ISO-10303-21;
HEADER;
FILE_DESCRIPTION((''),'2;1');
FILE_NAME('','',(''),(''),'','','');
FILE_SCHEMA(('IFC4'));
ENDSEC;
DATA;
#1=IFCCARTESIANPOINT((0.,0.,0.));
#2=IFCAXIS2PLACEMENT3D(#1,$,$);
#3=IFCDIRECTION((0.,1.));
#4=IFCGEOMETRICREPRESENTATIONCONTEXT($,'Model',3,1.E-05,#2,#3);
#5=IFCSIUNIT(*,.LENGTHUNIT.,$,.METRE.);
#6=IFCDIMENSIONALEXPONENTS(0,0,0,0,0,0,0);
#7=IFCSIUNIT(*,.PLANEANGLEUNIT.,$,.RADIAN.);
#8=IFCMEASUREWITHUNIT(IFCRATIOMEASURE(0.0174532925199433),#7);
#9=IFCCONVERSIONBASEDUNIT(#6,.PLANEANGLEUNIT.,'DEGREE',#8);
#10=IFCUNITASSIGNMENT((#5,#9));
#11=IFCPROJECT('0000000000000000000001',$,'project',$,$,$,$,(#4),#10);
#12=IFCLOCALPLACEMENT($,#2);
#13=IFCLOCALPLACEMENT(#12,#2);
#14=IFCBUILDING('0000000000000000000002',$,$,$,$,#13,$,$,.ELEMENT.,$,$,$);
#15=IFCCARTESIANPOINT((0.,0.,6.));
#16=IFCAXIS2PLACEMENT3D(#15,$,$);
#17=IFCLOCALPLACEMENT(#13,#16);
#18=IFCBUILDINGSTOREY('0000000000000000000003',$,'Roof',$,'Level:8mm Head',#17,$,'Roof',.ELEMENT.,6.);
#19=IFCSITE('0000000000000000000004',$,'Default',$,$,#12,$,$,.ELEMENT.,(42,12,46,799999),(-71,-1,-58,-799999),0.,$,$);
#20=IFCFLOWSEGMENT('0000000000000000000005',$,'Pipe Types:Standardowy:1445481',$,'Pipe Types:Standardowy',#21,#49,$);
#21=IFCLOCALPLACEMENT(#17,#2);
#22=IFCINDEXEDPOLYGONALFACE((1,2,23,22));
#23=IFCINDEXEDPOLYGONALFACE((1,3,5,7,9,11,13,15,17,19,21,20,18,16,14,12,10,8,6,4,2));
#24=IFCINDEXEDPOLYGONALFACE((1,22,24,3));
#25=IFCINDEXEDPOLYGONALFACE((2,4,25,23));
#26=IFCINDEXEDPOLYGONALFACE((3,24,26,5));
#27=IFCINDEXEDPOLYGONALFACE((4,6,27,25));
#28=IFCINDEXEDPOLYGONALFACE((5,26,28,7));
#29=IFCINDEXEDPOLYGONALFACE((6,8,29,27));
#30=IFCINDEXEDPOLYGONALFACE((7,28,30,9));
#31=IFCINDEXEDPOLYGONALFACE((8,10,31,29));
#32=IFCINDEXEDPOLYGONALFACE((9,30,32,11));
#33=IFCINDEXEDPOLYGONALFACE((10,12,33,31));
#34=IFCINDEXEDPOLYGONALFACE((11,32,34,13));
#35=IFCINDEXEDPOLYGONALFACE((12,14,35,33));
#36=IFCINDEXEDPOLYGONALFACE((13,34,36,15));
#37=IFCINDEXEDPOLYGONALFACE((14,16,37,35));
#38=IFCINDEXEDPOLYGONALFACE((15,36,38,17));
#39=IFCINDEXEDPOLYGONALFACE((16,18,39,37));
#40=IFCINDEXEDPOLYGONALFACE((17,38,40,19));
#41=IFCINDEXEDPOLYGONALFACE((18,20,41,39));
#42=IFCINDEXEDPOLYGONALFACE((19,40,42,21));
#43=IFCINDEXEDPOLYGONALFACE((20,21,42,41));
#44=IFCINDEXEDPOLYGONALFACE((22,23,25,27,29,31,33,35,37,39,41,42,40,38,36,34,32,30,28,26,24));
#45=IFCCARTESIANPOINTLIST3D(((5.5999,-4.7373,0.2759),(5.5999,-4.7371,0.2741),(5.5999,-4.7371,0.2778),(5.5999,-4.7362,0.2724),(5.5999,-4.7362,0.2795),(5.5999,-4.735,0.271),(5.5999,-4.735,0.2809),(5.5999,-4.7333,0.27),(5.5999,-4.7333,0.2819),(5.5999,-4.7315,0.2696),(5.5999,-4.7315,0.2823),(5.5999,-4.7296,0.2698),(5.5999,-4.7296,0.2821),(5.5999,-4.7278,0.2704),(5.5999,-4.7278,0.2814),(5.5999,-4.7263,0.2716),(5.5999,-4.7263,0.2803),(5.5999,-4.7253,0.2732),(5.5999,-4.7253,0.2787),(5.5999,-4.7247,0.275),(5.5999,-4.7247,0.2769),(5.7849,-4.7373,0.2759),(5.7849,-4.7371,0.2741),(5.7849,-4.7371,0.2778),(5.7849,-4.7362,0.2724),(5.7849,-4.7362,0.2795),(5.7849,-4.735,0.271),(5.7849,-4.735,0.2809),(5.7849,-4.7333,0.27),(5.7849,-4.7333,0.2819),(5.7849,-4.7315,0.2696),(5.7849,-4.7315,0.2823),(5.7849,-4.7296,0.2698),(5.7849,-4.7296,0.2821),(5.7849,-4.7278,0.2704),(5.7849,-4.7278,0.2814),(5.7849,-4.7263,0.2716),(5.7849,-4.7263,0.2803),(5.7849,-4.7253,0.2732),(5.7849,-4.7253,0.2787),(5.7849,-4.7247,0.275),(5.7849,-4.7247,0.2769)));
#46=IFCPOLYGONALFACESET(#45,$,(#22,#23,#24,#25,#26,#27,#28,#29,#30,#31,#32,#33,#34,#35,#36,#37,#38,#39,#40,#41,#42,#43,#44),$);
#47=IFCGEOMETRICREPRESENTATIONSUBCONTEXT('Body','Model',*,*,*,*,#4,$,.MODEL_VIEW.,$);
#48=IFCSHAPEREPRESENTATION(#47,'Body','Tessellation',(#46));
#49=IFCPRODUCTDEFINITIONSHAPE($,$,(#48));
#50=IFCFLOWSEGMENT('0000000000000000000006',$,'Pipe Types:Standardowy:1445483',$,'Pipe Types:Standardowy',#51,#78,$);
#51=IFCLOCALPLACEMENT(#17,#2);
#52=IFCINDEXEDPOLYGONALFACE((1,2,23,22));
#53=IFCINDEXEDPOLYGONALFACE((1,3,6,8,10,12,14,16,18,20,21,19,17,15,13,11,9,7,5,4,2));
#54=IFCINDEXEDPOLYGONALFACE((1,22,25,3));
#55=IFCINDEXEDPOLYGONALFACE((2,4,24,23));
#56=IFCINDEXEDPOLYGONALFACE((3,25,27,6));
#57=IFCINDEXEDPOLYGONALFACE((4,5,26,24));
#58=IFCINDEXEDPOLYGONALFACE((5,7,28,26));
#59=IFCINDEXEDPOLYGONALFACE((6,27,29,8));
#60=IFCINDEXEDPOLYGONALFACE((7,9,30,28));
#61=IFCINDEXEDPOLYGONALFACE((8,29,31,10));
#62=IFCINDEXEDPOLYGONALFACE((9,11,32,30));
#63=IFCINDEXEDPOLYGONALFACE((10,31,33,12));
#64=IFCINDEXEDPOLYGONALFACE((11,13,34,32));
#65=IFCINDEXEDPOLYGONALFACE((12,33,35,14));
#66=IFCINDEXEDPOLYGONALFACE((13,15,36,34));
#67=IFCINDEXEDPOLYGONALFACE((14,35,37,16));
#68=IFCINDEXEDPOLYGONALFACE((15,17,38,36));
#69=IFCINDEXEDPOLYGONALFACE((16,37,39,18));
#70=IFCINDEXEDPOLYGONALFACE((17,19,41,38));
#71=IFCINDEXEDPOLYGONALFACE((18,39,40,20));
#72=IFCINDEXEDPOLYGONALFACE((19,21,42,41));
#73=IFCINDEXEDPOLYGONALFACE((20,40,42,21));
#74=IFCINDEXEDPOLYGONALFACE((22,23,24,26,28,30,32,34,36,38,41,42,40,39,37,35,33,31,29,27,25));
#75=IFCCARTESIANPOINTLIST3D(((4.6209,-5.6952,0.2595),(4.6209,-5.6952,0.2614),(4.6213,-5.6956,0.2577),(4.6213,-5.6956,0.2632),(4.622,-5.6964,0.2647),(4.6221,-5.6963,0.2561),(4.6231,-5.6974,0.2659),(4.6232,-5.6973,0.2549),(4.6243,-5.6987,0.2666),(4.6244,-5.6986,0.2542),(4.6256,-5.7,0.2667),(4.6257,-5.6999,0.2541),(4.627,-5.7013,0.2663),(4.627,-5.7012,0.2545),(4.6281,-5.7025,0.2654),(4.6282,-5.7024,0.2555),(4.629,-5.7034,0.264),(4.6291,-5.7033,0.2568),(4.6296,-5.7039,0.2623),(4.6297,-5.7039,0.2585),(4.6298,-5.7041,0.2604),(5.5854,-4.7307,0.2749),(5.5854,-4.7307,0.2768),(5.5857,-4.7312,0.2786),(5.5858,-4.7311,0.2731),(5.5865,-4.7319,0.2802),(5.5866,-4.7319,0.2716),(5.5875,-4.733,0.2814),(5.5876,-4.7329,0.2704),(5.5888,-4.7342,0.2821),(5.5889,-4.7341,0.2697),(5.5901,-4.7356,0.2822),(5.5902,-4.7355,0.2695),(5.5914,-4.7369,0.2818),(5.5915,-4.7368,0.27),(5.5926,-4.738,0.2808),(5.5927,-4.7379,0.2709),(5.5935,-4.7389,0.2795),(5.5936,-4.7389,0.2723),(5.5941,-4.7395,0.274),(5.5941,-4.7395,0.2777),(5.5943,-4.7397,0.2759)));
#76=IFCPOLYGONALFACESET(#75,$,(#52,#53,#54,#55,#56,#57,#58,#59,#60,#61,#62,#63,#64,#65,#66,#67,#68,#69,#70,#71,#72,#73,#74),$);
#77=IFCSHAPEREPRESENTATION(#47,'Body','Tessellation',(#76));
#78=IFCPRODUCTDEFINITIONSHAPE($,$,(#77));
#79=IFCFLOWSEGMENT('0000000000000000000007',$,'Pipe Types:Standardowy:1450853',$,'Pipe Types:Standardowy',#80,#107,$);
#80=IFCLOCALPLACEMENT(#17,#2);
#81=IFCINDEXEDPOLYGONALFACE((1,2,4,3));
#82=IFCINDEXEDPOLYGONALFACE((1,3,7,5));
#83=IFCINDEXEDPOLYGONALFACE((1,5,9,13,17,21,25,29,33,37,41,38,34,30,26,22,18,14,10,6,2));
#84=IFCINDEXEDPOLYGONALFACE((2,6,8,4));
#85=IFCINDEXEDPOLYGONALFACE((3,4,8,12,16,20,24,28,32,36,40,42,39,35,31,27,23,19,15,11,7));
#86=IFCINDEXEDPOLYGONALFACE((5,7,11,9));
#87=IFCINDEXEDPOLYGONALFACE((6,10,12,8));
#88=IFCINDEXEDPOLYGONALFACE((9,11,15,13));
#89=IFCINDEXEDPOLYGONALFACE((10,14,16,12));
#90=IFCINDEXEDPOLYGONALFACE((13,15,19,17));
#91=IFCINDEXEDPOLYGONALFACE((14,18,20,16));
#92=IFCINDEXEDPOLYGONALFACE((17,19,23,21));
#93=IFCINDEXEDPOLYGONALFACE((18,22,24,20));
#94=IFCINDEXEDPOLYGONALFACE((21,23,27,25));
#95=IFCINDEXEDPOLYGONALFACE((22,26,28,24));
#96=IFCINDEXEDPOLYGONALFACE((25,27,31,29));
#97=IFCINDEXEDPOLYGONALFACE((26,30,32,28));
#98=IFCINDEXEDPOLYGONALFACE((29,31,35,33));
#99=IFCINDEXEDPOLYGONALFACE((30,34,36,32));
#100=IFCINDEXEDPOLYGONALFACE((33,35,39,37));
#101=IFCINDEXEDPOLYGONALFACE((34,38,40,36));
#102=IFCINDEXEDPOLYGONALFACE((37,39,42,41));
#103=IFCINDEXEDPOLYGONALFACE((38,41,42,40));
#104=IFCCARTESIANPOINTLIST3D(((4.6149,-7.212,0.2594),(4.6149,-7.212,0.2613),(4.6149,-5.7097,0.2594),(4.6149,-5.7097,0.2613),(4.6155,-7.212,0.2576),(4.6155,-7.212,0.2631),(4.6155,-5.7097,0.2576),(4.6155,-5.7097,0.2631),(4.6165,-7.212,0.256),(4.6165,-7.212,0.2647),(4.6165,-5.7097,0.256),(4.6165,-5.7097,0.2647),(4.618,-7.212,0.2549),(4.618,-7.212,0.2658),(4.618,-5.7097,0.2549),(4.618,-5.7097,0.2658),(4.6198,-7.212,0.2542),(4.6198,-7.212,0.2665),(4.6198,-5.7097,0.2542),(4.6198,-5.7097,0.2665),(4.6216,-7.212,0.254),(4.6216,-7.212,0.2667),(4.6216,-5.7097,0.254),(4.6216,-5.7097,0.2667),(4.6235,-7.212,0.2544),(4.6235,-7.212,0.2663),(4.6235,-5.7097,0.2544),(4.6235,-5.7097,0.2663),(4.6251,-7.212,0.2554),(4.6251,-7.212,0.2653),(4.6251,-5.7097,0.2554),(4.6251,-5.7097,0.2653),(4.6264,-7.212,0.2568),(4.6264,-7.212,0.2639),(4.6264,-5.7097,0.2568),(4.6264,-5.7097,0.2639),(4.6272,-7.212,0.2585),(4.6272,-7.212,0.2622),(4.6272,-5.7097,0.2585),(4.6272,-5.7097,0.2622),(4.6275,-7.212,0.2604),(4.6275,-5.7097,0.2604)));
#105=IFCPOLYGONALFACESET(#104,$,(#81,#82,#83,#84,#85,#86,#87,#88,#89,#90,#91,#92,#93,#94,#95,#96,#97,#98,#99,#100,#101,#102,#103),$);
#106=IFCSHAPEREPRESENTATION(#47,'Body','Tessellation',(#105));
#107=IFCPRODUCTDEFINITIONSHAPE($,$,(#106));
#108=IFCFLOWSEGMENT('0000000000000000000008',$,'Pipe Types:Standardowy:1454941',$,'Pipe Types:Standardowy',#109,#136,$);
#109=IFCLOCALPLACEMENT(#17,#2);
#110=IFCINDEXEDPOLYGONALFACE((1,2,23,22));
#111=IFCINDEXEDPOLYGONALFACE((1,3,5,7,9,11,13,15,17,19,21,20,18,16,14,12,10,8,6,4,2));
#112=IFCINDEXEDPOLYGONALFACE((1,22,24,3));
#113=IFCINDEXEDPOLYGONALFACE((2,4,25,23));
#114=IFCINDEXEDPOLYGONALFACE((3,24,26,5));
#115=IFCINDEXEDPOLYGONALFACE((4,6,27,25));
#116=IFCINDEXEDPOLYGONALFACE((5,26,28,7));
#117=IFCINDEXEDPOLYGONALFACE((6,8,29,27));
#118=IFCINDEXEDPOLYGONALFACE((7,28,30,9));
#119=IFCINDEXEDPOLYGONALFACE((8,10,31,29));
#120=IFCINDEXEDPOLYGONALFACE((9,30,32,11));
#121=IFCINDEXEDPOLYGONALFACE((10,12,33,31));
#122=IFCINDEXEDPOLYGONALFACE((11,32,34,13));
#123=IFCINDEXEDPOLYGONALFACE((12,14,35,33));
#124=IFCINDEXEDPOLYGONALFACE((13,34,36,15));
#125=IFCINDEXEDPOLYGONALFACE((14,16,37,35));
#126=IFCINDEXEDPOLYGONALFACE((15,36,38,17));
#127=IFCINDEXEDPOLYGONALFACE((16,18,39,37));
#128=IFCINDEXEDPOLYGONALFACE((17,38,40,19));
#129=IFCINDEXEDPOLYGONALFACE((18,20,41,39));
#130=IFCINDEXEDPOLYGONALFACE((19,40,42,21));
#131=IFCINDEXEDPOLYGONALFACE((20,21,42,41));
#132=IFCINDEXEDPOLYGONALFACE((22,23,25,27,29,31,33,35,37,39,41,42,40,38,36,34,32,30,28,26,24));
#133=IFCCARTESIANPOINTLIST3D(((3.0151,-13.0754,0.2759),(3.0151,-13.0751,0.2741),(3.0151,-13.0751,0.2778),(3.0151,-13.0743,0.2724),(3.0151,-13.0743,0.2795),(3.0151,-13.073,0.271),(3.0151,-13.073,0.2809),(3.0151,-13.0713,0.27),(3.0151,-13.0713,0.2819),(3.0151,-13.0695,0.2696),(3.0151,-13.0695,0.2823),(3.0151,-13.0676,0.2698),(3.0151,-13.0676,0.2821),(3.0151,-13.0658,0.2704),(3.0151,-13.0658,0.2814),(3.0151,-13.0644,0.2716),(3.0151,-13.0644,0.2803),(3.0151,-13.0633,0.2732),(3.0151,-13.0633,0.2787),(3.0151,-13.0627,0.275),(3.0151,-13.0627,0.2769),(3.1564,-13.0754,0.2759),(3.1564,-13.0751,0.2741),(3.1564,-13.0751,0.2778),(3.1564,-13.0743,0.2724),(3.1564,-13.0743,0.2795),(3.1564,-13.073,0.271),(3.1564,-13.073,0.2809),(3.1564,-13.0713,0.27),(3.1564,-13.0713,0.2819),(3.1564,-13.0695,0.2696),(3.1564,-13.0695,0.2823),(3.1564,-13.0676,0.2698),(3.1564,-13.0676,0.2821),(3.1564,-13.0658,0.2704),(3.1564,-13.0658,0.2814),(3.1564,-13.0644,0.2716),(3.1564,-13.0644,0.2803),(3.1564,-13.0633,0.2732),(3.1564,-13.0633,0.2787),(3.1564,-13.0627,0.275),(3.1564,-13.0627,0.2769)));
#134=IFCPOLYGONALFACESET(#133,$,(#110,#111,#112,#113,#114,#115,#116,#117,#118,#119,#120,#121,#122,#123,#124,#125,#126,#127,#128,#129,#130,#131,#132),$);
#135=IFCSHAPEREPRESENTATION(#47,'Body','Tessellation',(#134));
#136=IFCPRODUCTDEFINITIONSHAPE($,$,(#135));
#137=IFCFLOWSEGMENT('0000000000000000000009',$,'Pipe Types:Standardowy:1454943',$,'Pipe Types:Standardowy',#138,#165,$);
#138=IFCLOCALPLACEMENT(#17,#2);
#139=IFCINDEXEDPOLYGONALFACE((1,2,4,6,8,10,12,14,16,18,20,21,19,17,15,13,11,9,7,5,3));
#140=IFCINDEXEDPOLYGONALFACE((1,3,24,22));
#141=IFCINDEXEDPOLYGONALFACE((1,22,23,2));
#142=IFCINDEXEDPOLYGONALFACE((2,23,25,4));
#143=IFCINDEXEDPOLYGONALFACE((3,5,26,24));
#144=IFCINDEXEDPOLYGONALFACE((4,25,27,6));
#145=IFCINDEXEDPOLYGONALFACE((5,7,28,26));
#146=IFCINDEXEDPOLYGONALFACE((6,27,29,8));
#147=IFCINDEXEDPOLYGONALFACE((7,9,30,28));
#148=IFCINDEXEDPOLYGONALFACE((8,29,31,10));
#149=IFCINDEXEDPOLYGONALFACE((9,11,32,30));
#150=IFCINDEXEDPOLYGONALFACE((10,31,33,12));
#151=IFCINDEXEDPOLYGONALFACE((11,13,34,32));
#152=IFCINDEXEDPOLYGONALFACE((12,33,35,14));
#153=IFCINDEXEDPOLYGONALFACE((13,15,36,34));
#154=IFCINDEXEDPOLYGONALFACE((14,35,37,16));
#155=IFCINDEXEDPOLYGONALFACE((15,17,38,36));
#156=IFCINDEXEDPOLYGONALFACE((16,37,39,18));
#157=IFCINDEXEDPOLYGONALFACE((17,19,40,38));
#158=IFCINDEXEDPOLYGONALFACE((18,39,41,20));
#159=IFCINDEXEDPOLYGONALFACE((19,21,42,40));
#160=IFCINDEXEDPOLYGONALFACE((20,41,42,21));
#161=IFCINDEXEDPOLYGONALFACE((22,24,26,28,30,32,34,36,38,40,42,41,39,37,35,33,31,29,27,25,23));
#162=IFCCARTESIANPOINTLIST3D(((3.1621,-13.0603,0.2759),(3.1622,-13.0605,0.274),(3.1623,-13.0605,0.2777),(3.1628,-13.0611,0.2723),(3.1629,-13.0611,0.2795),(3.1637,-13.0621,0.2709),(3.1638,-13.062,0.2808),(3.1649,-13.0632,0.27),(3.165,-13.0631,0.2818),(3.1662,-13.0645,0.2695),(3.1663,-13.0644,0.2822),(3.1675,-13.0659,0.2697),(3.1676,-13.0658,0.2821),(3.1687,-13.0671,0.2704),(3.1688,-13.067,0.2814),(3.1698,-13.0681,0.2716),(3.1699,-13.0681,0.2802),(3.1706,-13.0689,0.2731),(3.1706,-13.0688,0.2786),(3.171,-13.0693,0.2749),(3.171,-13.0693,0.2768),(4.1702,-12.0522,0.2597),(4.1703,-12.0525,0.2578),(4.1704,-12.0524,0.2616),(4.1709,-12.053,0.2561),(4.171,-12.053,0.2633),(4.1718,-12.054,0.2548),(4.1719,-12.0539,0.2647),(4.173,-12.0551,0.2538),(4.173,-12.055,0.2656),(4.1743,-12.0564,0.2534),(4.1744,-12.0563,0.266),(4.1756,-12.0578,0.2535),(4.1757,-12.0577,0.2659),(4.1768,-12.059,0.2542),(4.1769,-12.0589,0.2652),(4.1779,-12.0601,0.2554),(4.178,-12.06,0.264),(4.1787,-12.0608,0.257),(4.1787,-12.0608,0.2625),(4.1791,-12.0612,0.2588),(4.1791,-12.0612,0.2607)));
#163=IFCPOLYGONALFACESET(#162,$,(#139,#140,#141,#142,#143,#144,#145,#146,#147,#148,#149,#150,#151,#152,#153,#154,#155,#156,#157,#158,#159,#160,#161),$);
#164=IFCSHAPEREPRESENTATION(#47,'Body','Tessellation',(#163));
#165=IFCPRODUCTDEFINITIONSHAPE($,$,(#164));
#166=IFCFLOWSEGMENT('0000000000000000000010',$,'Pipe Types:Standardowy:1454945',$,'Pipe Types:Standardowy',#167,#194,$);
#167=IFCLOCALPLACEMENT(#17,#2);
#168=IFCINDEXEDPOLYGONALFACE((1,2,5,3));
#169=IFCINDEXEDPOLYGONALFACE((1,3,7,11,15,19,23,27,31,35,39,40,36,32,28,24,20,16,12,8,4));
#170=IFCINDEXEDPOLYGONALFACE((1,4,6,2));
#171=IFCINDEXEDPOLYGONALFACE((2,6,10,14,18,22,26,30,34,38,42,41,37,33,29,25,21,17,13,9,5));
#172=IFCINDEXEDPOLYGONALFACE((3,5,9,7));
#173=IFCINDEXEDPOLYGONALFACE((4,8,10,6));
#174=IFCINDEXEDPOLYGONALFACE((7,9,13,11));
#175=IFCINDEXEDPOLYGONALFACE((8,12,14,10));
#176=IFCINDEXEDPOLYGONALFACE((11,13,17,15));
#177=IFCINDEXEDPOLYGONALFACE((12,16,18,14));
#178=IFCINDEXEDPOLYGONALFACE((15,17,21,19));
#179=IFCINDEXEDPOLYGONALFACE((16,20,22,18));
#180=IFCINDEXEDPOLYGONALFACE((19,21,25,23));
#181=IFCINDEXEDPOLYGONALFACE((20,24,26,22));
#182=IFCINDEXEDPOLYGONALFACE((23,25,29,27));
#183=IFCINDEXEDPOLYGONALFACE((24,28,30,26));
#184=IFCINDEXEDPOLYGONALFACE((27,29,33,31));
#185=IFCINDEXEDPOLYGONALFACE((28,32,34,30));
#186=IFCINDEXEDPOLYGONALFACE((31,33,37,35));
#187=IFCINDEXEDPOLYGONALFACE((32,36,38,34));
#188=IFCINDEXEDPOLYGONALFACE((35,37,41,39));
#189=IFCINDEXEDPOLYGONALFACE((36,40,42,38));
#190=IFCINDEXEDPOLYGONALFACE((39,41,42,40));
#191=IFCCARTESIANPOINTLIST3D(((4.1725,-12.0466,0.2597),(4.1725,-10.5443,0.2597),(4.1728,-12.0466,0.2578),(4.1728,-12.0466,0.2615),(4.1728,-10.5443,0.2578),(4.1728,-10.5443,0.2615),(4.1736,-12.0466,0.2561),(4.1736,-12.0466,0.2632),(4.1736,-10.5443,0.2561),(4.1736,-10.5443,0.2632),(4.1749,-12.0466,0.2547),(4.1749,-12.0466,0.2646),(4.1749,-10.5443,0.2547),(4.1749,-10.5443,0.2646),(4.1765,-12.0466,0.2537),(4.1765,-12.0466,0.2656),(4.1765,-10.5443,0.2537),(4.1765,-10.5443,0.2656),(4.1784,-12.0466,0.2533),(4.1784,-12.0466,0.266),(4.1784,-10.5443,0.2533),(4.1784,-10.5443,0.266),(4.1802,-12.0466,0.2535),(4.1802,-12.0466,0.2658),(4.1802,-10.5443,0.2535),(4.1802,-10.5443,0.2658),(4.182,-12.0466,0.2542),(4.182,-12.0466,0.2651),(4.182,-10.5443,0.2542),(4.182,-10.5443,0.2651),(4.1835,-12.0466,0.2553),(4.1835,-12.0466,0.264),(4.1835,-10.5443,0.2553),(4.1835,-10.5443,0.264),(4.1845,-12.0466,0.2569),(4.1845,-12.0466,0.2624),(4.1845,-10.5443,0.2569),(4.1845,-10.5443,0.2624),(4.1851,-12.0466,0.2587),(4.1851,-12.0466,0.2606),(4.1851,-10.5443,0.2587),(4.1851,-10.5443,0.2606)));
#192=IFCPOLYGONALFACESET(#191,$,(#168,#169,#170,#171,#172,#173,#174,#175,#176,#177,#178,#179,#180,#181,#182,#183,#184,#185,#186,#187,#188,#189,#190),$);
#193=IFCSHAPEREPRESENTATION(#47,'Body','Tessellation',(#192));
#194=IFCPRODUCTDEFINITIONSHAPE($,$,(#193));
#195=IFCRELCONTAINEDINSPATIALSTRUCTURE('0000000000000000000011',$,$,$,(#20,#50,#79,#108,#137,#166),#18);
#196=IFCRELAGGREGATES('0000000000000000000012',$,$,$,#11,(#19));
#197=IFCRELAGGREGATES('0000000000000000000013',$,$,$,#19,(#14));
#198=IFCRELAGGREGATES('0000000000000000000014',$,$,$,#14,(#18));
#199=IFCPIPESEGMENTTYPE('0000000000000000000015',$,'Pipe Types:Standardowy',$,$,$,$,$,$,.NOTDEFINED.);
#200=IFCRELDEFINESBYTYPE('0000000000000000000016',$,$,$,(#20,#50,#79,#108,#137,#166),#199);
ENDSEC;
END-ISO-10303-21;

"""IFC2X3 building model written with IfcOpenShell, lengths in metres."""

from ifc_helpers import new_model, entity, si_unit, converted_unit, direction, frame, frame_2d, origin, origin_2d_with_axis, place, context, subcontext, project, spatial, circle, extrude, type_object, element, save


model = new_model("IFC2X3")

# Units and contexts
model_context = context("Model", 3, precision=1e-05, world=origin(), true_north=direction((0.0, 1.0)))
body_context = subcontext(model_context, "Body", "Model", "MODEL_VIEW")
ifc_project = project(units=[si_unit("LENGTHUNIT", "METRE"), converted_unit("PLANEANGLEUNIT", "DEGREE", entity("IfcRatioMeasure", 0.0174532925199433), si_unit("PLANEANGLEUNIT", "RADIAN"), dimensions=[0, 0, 0, 0, 0, 0, 0])], contexts=[model_context])

# Site, building, storey
site_placement = place(None, origin())
site = spatial("IfcSite", under=ifc_project, at=site_placement, Name="Default", CompositionType="ELEMENT", RefLatitude=(42, 12, 46, 799999), RefLongitude=(-71, -1, -58, -799999), RefElevation=0.0)
building_placement = place(site_placement, origin())
building = spatial("IfcBuilding", under=site, at=building_placement, CompositionType="ELEMENT")
storey_placement = place(building_placement, frame((0.0, 0.0, 6.0)))
storey = spatial("IfcBuildingStorey", under=building, at=storey_placement, Name="Roof", ObjectType="Level:8mm Head", LongName="Roof", CompositionType="ELEMENT", Elevation=6.0)

# Flow segments
pipe_segment_type = type_object("IfcPipeSegmentType", Name="Pipe Types:Standardowy", PredefinedType="NOTDEFINED")
flow_segment_1_placement = place(storey_placement, origin())
element("IfcFlowSegment", 1, at=flow_segment_1_placement, inside=storey, type_object=pipe_segment_type, Name="Pipe Types:Standardowy:1445481", ObjectType="Pipe Types:Standardowy", context=body_context, shape_type="SweptSolid", body=[
    extrude(circle(Radius=0.0063, at=frame_2d((0.0, 0.0), x_axis=(1.0, 0.0))), frame((5.5999, -4.731, 0.2759), z_axis=(1.0, 0.0, 0.0), x_axis=(0.0, -1.0, 0.0)), (0.0, 0.0, 1.0), 0.185),
])
flow_segment_2_placement = place(storey_placement, origin())
element("IfcFlowSegment", 2, at=flow_segment_2_placement, inside=storey, type_object=pipe_segment_type, Name="Pipe Types:Standardowy:1445483", ObjectType="Pipe Types:Standardowy", context=body_context, shape_type="SweptSolid", body=[
    extrude(circle(Radius=0.0063, at=origin_2d_with_axis()), frame((4.6254, -5.6996, 0.2604), z_axis=(0.707061, 0.707061, 0.011333), x_axis=(0.707107, -0.707107, 0.0)), (0.0, 0.0, 1.0), 1.364),
])
flow_segment_3_placement = place(storey_placement, origin())
element("IfcFlowSegment", 3, at=flow_segment_3_placement, inside=storey, type_object=pipe_segment_type, Name="Pipe Types:Standardowy:1450853", ObjectType="Pipe Types:Standardowy", context=body_context, shape_type="SweptSolid", body=[
    extrude(circle(Radius=0.0063, at=origin_2d_with_axis()), frame((4.6212, -7.212, 0.2604), z_axis=(0.0, 1.0, 0.0), x_axis=(1.0, 0.0, 0.0)), (0.0, 0.0, 1.0), 1.5023),
])
flow_segment_4_placement = place(storey_placement, origin())
element("IfcFlowSegment", 4, at=flow_segment_4_placement, inside=storey, type_object=pipe_segment_type, Name="Pipe Types:Standardowy:1454941", ObjectType="Pipe Types:Standardowy", context=body_context, shape_type="SweptSolid", body=[
    extrude(circle(Radius=0.0063, at=origin_2d_with_axis()), frame((3.0151, -13.069, 0.2759), z_axis=(1.0, 0.0, 0.0), x_axis=(0.0, -1.0, 0.0)), (0.0, 0.0, 1.0), 0.1414),
])
flow_segment_5_placement = place(storey_placement, origin())
element("IfcFlowSegment", 5, at=flow_segment_5_placement, inside=storey, type_object=pipe_segment_type, Name="Pipe Types:Standardowy:1454943", ObjectType="Pipe Types:Standardowy", context=body_context, shape_type="SweptSolid", body=[
    extrude(circle(Radius=0.0063, at=origin_2d_with_axis()), frame((4.1746, -12.0567, 0.2597), z_axis=(-0.707061, -0.707061, 0.011333), x_axis=(-0.707107, 0.707107, 0.0)), (0.0, 0.0, 1.0), 1.4258),
])
flow_segment_6_placement = place(storey_placement, origin())
element("IfcFlowSegment", 6, at=flow_segment_6_placement, inside=storey, type_object=pipe_segment_type, Name="Pipe Types:Standardowy:1454945", ObjectType="Pipe Types:Standardowy", context=body_context, shape_type="SweptSolid", body=[
    extrude(circle(Radius=0.0063, at=frame_2d((0.0, 0.0), x_axis=(1.0, 0.0))), frame((4.1788, -12.0466, 0.2597), z_axis=(0.0, 1.0, 0.0), x_axis=(-1.0, 0.0, 0.0)), (0.0, 0.0, 1.0), 1.5023),
])

save(model, "model.ifc")
